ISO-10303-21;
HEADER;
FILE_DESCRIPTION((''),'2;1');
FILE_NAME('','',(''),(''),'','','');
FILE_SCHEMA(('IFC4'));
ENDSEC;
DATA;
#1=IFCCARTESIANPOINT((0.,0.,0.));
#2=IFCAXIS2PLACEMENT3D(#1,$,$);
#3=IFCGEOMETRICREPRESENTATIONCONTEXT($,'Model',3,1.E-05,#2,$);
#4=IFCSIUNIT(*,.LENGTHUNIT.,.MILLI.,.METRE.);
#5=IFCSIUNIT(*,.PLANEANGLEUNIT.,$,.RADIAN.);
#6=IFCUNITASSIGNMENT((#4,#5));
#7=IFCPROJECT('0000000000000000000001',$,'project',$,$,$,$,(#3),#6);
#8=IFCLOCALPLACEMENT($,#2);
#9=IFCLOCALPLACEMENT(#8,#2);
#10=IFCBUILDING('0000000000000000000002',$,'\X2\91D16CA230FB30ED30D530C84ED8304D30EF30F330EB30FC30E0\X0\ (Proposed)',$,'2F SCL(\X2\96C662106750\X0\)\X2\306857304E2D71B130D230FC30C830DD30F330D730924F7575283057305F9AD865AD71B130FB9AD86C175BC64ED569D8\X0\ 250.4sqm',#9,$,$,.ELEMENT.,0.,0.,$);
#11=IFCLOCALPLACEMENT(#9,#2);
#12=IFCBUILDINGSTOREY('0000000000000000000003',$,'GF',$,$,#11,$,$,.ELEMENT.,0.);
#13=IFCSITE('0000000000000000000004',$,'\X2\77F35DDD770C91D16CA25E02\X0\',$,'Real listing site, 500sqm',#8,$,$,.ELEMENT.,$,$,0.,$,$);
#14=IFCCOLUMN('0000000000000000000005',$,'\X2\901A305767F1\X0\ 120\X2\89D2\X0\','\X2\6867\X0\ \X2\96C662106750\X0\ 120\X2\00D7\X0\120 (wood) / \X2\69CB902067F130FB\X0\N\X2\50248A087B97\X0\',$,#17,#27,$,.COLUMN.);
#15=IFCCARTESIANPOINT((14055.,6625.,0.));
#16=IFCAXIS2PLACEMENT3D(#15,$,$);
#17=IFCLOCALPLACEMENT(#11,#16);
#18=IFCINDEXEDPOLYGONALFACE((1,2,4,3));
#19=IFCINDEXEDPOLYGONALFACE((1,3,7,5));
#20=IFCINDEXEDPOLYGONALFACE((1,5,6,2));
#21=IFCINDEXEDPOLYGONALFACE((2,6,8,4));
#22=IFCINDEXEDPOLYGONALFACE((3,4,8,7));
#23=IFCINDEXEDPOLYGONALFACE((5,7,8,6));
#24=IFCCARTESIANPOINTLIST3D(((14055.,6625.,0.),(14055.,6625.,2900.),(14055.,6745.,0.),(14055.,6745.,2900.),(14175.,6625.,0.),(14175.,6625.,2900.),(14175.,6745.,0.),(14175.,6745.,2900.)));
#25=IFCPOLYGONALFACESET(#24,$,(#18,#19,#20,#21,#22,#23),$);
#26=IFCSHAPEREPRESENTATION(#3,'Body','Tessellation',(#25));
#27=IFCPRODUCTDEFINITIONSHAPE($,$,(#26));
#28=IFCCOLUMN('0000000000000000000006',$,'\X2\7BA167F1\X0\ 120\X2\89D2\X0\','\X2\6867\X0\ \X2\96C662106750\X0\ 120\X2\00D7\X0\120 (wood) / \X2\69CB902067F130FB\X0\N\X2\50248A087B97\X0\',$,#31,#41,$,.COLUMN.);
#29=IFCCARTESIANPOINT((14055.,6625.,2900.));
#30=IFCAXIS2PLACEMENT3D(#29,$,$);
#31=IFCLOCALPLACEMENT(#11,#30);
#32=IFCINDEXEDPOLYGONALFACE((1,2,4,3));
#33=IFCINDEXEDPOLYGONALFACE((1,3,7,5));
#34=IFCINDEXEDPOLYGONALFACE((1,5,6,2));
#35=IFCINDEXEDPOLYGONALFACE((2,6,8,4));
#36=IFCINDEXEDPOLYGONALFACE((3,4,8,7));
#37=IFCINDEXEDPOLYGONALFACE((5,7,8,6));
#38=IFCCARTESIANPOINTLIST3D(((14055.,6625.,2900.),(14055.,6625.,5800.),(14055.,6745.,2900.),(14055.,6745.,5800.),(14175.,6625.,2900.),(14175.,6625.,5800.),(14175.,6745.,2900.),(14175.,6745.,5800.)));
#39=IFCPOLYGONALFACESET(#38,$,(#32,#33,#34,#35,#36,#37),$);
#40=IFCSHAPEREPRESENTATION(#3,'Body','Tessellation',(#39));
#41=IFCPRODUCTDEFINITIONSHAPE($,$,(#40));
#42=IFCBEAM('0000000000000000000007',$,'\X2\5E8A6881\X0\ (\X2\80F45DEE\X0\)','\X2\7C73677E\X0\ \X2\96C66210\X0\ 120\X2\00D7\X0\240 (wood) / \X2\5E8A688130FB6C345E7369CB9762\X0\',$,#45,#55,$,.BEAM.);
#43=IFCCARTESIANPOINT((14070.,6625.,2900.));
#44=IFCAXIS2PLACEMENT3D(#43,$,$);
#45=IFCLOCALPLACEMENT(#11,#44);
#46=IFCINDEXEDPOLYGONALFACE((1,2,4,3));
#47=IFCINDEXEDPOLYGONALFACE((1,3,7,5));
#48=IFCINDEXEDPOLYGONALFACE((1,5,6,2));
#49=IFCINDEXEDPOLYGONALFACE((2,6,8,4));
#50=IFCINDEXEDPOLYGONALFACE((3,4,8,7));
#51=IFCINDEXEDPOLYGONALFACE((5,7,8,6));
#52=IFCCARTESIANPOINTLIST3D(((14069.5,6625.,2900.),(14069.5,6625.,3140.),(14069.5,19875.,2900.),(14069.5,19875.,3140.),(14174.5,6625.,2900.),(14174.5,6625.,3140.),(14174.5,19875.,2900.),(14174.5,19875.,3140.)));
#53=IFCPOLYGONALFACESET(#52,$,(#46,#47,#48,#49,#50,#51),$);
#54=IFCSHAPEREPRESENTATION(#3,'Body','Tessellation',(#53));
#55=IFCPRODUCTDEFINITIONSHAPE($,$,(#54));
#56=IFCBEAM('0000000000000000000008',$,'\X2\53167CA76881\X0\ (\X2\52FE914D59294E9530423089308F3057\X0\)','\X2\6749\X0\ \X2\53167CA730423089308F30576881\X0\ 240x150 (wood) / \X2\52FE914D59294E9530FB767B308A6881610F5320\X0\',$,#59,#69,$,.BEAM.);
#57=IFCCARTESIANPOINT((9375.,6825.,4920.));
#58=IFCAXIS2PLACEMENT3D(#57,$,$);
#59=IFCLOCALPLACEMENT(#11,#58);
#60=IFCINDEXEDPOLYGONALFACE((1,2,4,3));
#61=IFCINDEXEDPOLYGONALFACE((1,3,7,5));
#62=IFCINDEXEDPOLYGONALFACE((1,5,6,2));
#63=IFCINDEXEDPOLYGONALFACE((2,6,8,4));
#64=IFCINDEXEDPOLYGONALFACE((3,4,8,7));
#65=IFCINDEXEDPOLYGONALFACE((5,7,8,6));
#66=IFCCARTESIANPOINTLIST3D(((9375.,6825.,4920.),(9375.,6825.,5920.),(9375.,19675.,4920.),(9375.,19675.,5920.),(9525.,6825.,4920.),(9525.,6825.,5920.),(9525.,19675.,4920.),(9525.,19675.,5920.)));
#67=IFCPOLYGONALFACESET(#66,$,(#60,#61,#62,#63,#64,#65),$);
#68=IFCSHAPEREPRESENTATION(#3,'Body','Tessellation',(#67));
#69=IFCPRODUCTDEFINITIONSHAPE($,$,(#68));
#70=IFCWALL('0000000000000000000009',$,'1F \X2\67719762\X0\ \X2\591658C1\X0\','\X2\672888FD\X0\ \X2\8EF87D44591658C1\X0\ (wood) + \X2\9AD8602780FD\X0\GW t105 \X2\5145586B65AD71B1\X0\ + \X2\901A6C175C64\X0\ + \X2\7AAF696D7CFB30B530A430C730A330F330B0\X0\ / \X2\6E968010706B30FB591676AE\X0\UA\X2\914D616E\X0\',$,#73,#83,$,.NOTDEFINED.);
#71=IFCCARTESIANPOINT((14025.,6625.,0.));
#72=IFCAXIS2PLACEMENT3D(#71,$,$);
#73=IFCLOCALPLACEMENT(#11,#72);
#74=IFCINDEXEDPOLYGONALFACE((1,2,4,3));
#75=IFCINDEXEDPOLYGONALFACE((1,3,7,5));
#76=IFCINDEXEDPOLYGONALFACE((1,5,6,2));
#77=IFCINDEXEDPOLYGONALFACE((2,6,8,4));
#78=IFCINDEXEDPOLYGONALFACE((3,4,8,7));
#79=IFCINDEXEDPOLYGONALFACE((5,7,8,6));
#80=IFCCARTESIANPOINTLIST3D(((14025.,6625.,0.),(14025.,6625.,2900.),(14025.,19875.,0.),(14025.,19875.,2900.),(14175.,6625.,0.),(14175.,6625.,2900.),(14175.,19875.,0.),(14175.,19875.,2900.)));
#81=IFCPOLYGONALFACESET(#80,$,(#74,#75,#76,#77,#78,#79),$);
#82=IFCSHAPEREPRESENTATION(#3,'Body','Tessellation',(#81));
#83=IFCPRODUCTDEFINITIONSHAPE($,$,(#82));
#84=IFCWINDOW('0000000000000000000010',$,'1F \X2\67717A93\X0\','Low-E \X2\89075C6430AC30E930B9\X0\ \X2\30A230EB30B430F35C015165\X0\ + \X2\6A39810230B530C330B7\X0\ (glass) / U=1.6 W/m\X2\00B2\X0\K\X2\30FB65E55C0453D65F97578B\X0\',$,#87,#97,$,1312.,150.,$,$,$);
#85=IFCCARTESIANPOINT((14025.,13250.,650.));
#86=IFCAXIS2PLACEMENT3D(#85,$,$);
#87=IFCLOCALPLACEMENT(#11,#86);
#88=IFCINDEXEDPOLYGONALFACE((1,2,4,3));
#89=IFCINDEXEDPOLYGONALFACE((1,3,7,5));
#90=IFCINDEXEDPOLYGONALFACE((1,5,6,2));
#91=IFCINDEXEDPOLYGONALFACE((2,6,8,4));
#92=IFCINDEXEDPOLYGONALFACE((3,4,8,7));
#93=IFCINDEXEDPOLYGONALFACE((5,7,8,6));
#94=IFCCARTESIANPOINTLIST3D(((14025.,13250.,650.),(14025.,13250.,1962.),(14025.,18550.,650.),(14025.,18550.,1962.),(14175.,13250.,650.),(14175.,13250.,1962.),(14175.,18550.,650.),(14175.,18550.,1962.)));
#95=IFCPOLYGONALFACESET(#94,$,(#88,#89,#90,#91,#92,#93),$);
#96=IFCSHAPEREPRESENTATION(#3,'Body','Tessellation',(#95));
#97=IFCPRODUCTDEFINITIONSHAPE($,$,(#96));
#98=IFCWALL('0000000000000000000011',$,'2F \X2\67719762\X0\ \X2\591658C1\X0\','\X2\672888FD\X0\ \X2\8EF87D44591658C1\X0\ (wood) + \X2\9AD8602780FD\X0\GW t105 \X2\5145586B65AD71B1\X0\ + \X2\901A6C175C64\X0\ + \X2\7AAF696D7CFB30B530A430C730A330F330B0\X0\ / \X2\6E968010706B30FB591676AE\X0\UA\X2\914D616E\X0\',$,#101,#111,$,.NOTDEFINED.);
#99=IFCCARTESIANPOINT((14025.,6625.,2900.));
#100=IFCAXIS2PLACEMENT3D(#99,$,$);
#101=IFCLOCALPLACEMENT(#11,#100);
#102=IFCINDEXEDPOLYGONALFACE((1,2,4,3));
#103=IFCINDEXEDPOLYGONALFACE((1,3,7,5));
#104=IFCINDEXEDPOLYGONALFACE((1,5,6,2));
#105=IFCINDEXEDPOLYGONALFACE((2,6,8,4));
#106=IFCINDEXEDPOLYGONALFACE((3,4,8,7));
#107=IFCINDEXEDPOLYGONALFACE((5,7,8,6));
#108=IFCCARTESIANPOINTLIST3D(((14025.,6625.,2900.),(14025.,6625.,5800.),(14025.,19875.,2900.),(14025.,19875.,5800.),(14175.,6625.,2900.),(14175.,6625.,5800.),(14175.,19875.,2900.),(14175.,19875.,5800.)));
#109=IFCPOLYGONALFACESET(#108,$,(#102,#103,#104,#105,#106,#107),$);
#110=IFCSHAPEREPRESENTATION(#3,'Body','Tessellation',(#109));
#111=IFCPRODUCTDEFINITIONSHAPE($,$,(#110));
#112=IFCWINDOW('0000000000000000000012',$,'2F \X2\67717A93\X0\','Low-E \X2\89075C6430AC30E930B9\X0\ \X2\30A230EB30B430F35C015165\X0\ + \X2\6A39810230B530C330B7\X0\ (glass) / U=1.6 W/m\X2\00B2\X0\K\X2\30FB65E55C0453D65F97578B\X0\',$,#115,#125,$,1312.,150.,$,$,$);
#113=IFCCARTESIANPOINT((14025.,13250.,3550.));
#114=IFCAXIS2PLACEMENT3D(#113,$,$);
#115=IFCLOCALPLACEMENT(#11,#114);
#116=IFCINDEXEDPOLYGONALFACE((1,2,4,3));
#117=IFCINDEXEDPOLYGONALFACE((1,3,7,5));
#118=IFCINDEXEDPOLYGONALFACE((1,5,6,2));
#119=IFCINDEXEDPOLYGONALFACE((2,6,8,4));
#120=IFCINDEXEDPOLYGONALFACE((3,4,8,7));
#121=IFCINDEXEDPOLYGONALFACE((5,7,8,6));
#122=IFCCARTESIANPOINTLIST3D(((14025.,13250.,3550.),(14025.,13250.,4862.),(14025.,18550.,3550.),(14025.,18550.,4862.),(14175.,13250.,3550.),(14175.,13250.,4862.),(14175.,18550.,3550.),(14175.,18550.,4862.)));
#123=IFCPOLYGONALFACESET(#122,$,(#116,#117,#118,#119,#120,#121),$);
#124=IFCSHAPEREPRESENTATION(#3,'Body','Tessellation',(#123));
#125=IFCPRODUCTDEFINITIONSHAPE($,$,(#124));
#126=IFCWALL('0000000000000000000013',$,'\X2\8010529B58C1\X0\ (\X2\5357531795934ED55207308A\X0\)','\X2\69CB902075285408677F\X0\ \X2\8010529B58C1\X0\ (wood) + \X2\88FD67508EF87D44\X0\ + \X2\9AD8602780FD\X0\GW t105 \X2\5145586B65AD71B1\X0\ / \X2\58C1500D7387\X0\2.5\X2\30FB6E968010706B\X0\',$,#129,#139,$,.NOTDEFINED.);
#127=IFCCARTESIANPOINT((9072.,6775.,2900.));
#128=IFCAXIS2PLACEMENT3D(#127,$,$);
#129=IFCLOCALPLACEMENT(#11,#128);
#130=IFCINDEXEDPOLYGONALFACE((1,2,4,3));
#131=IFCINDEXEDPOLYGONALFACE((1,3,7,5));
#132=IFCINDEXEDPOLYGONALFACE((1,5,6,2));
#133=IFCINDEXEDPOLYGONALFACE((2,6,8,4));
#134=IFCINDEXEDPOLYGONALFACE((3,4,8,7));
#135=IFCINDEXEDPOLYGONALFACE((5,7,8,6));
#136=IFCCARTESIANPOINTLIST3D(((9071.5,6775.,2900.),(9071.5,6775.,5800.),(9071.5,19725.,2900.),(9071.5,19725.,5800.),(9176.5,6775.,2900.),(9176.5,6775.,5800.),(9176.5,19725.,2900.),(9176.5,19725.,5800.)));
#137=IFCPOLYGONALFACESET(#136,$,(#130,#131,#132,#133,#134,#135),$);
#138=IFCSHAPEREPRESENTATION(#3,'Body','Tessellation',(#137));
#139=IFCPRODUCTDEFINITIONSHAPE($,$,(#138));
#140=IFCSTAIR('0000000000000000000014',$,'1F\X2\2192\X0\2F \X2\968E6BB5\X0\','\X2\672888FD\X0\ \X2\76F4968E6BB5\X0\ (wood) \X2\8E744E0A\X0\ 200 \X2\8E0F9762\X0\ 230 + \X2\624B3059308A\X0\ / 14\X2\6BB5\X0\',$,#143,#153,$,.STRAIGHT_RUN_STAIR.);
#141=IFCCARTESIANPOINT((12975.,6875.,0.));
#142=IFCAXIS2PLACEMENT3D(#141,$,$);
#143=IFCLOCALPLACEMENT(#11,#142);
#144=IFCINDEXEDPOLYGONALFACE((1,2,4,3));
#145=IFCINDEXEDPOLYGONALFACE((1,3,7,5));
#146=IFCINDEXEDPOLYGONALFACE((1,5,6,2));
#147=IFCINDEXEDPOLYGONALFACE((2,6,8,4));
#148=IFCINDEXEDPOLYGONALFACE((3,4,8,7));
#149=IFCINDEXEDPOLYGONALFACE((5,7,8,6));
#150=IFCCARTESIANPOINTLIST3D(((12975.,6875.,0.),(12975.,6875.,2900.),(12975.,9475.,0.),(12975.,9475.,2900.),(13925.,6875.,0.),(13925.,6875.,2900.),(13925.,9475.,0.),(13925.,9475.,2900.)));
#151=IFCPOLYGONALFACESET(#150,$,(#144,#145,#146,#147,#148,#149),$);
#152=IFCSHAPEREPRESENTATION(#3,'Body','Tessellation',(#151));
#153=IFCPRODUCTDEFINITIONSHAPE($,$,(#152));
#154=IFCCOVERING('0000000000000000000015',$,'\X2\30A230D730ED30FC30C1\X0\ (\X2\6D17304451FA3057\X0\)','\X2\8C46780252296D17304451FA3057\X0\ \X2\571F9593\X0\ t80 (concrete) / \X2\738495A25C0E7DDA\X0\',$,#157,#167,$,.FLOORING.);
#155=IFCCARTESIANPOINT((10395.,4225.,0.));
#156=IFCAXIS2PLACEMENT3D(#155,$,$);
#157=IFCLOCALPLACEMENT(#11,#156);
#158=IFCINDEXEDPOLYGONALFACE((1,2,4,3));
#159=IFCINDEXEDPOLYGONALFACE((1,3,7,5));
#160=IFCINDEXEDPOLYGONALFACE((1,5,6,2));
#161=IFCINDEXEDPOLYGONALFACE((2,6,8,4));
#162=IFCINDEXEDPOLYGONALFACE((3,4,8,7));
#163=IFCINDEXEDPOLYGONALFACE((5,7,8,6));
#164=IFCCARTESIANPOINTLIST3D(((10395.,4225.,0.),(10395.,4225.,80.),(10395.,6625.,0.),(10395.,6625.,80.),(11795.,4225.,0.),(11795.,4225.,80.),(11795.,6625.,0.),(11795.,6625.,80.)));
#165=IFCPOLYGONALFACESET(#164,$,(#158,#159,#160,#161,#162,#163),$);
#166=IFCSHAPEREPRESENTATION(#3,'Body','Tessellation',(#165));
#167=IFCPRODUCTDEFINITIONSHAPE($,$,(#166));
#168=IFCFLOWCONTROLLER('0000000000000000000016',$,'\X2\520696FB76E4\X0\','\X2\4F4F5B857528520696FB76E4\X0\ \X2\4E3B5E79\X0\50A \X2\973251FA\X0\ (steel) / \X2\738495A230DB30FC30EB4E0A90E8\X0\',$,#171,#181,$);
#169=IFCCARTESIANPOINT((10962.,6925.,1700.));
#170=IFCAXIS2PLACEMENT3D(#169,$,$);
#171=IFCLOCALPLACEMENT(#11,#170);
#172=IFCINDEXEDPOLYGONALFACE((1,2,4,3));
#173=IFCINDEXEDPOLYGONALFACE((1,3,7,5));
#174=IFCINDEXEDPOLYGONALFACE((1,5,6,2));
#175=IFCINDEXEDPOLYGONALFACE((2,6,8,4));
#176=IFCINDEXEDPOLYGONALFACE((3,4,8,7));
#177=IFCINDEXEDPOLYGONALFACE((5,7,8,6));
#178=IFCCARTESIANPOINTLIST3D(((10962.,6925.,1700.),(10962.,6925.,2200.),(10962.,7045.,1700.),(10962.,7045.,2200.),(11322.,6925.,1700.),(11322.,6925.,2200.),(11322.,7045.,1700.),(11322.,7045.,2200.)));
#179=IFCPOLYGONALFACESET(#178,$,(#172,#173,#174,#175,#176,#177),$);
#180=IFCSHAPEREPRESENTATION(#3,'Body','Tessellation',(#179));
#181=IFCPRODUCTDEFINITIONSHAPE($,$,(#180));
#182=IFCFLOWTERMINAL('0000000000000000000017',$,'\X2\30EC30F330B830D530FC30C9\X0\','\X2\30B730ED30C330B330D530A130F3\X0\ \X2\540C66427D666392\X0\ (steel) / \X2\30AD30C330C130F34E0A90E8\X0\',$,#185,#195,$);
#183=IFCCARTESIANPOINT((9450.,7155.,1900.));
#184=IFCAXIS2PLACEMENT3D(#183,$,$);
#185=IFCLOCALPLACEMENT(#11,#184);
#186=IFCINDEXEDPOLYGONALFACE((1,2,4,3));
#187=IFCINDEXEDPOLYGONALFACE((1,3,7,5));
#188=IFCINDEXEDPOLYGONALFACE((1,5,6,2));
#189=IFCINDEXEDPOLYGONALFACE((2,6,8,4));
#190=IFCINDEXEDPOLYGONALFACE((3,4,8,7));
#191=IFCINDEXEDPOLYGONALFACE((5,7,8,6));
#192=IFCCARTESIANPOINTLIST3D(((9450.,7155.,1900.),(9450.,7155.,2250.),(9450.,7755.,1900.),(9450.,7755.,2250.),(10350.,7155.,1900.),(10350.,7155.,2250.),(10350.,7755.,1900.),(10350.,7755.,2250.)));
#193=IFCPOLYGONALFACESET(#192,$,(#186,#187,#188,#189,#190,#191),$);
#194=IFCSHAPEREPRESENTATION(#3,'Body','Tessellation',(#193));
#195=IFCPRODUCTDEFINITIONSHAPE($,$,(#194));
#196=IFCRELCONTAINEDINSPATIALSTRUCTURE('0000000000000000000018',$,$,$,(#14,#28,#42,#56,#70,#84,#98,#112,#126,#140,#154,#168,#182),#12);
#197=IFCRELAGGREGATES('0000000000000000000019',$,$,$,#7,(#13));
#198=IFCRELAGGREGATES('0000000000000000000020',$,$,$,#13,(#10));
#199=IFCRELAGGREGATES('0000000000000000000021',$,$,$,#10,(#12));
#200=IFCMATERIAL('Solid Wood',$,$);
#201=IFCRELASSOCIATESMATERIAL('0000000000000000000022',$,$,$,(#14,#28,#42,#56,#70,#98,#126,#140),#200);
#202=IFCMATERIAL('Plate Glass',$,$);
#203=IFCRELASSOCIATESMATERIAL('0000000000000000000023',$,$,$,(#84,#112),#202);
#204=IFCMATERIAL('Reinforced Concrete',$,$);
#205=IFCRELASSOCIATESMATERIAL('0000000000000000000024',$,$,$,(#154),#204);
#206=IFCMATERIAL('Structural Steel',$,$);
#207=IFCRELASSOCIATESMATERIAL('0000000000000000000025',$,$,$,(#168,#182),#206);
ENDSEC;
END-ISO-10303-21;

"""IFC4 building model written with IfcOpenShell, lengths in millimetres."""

from ifc_helpers import new_model, si_unit, frame, frame_2d, origin, place, context, project, spatial, rectangle, extrude, material, element, fill, save


model = new_model("IFC4")

# Units and contexts
model_context = context("Model", 3, precision=1e-05, world=origin())
ifc_project = project(units=[si_unit("LENGTHUNIT", "METRE", prefix="MILLI"), si_unit("PLANEANGLEUNIT", "RADIAN")], contexts=[model_context])

# Site, building, storey
site_placement = place(None, origin())
site = spatial("IfcSite", under=ifc_project, at=site_placement, Name="石川県金沢市", ObjectType="Real listing site, 500sqm", CompositionType="ELEMENT", RefElevation=0.0)
building_placement = place(site_placement, origin())
building = spatial("IfcBuilding", under=site, at=building_placement, Name="金沢・ロフト付きワンルーム (Proposed)", ObjectType="2F SCL(集成材)と地中熱ヒートポンプを併用した高断熱・高気密仕様 250.4sqm", CompositionType="ELEMENT", ElevationOfRefHeight=0.0, ElevationOfTerrain=0.0)
storey_placement = place(building_placement, origin())
storey = spatial("IfcBuildingStorey", under=building, at=storey_placement, Name="GF", CompositionType="ELEMENT", Elevation=0.0)

# Columns
ifc_material_1 = material(Name="Solid Wood")
column_1_placement = place(storey_placement, frame((14055.0, 6625.0, 0.0)))
element("IfcColumn", 1, at=column_1_placement, inside=storey, material=ifc_material_1, Name="通し柱 120角", Description="桧 集成材 120×120 (wood) / 構造柱・N値計算", PredefinedType="COLUMN", context=model_context, shape_type="SweptSolid", body=[
    extrude(rectangle(XDim=120.0, YDim=120.0, at=frame_2d((60.0, 60.0))), frame((14055.0, 6625.0, 0.0)), (0.0, 0.0, 1.0), 2900.0),
])
column_2_placement = place(storey_placement, frame((14055.0, 6625.0, 2900.0)))
element("IfcColumn", 2, at=column_2_placement, inside=storey, material=ifc_material_1, Name="管柱 120角", Description="桧 集成材 120×120 (wood) / 構造柱・N値計算", PredefinedType="COLUMN", context=model_context, shape_type="SweptSolid", body=[
    extrude(rectangle(XDim=120.0, YDim=120.0, at=frame_2d((60.0, 60.0))), frame((14055.0, 6625.0, 2900.0)), (0.0, 0.0, 1.0), 2900.0),
])

# Beams
beam_1_placement = place(storey_placement, frame((14070.0, 6625.0, 2900.0)))
element("IfcBeam", 3, at=beam_1_placement, inside=storey, material=ifc_material_1, Name="床梁 (胴差)", Description="米松 集成 120×240 (wood) / 床梁・水平構面", PredefinedType="BEAM", context=model_context, shape_type="SweptSolid", body=[
    extrude(rectangle(XDim=105.0, YDim=13250.0, at=frame_2d((52.0, 6625.0))), frame((14070.0, 6625.0, 2900.0)), (0.0, 0.0, 1.0), 240.0),
])
beam_2_placement = place(storey_placement, frame((9375.0, 6825.0, 4920.0)))
element("IfcBeam", 4, at=beam_2_placement, inside=storey, material=ifc_material_1, Name="化粧梁 (勾配天井あらわし)", Description="杉 化粧あらわし梁 240x150 (wood) / 勾配天井・登り梁意匠", PredefinedType="BEAM", context=model_context, shape_type="SweptSolid", body=[
    extrude(rectangle(XDim=150.0, YDim=12850.0, at=frame_2d((75.0, 6425.0))), frame((9375.0, 6825.0, 4920.0)), (0.0, 0.0, 1.0), 1000.0),
])

# Wall, opening, window
wall_1_placement = place(storey_placement, frame((14025.0, 6625.0, 0.0)))
wall_1 = element("IfcWall", 5, at=wall_1_placement, inside=storey, material=ifc_material_1, Name="1F 東面 外壁", Description="木製 軸組外壁 (wood) + 高性能GW t105 充填断熱 + 通気層 + 窯業系サイディング / 準耐火・外皮UA配慮", PredefinedType="NOTDEFINED", context=model_context, shape_type="SweptSolid", body=[
    extrude(rectangle(XDim=150.0, YDim=13250.0, at=frame_2d((75.0, 6625.0))), frame((14025.0, 6625.0, 0.0)), (0.0, 0.0, 1.0), 2900.0),
])
opening_1_placement = place(storey_placement, frame((14025.0, 13250.0, 650.0)))
opening_1 = element("IfcOpeningElement", 6, at=opening_1_placement, cuts=wall_1, PredefinedType="NOTDEFINED", context=model_context, shape_type="SweptSolid", body=[
    extrude(rectangle(XDim=150.0, YDim=5300.0, at=frame_2d((75.0, 2650.0))), frame((14025.0, 13250.0, 650.0)), (0.0, 0.0, 1.0), 1312.0),
])
ifc_material_2 = material(Name="Plate Glass")
window_1_placement = place(storey_placement, frame((14025.0, 13250.0, 650.0)))
window_1 = element("IfcWindow", 7, at=window_1_placement, inside=storey, material=ifc_material_2, Name="1F 東窓", Description="Low-E 複層ガラス アルゴン封入 + 樹脂サッシ (glass) / U=1.6 W/m²K・日射取得型", OverallHeight=1312.0, OverallWidth=150.0, context=model_context, shape_type="SweptSolid", body=[
    extrude(rectangle(XDim=150.0, YDim=5300.0, at=frame_2d((75.0, 2650.0))), frame((14025.0, 13250.0, 650.0)), (0.0, 0.0, 1.0), 1312.0),
])
fill(opening_1, window_1)

# Wall, opening, window
wall_2_placement = place(storey_placement, frame((14025.0, 6625.0, 2900.0)))
wall_2 = element("IfcWall", 8, at=wall_2_placement, inside=storey, material=ifc_material_1, Name="2F 東面 外壁", Description="木製 軸組外壁 (wood) + 高性能GW t105 充填断熱 + 通気層 + 窯業系サイディング / 準耐火・外皮UA配慮", PredefinedType="NOTDEFINED", context=model_context, shape_type="SweptSolid", body=[
    extrude(rectangle(XDim=150.0, YDim=13250.0, at=frame_2d((75.0, 6625.0))), frame((14025.0, 6625.0, 2900.0)), (0.0, 0.0, 1.0), 2900.0),
])
opening_2_placement = place(storey_placement, frame((14025.0, 13250.0, 3550.0)))
opening_2 = element("IfcOpeningElement", 9, at=opening_2_placement, cuts=wall_2, PredefinedType="NOTDEFINED", context=model_context, shape_type="SweptSolid", body=[
    extrude(rectangle(XDim=150.0, YDim=5300.0, at=frame_2d((75.0, 2650.0))), frame((14025.0, 13250.0, 3550.0)), (0.0, 0.0, 1.0), 1312.0),
])
window_2_placement = place(storey_placement, frame((14025.0, 13250.0, 3550.0)))
window_2 = element("IfcWindow", 10, at=window_2_placement, inside=storey, material=ifc_material_2, Name="2F 東窓", Description="Low-E 複層ガラス アルゴン封入 + 樹脂サッシ (glass) / U=1.6 W/m²K・日射取得型", OverallHeight=1312.0, OverallWidth=150.0, context=model_context, shape_type="SweptSolid", body=[
    extrude(rectangle(XDim=150.0, YDim=5300.0, at=frame_2d((75.0, 2650.0))), frame((14025.0, 13250.0, 3550.0)), (0.0, 0.0, 1.0), 1312.0),
])
fill(opening_2, window_2)

# Wall
wall_3_placement = place(storey_placement, frame((9072.0, 6775.0, 2900.0)))
element("IfcWall", 11, at=wall_3_placement, inside=storey, material=ifc_material_1, Name="耐力壁 (南北間仕切り)", Description="構造用合板 耐力壁 (wood) + 製材軸組 + 高性能GW t105 充填断熱 / 壁倍率2.5・準耐火", PredefinedType="NOTDEFINED", context=model_context, shape_type="SweptSolid", body=[
    extrude(rectangle(XDim=105.0, YDim=12950.0, at=frame_2d((52.0, 6475.0))), frame((9072.0, 6775.0, 2900.0)), (0.0, 0.0, 1.0), 2900.0),
])

# Stair
stair_placement = place(storey_placement, frame((12975.0, 6875.0, 0.0)))
element("IfcStair", 12, at=stair_placement, inside=storey, material=ifc_material_1, Name="1F→2F 階段", Description="木製 直階段 (wood) 蹴上 200 踏面 230 + 手すり / 14段", PredefinedType="STRAIGHT_RUN_STAIR", context=model_context, shape_type="SweptSolid", body=[
    extrude(rectangle(XDim=950.0, YDim=2600.0, at=frame_2d((475.0, 1300.0))), frame((12975.0, 6875.0, 0.0)), (0.0, 0.0, 1.0), 2900.0),
])

# Covering
ifc_material_3 = material(Name="Reinforced Concrete")
covering_placement = place(storey_placement, frame((10395.0, 4225.0, 0.0)))
element("IfcCovering", 13, at=covering_placement, inside=storey, material=ifc_material_3, Name="アプローチ (洗い出し)", Description="豆砂利洗い出し 土間 t80 (concrete) / 玄関導線", PredefinedType="FLOORING", context=model_context, shape_type="SweptSolid", body=[
    extrude(rectangle(XDim=1400.0, YDim=2400.0, at=frame_2d((700.0, 1200.0))), frame((10395.0, 4225.0, 0.0)), (0.0, 0.0, 1.0), 80.0),
])

# Flow controller
ifc_material_4 = material(Name="Structural Steel")
flow_controller_placement = place(storey_placement, frame((10962.0, 6925.0, 1700.0)))
element("IfcFlowController", 14, at=flow_controller_placement, inside=storey, material=ifc_material_4, Name="分電盤", Description="住宅用分電盤 主幹50A 露出 (steel) / 玄関ホール上部", context=model_context, shape_type="SweptSolid", body=[
    extrude(rectangle(XDim=360.0, YDim=120.0, at=frame_2d((180.0, 60.0))), frame((10962.0, 6925.0, 1700.0)), (0.0, 0.0, 1.0), 500.0),
])

# Flow terminal
flow_terminal_1_placement = place(storey_placement, frame((9450.0, 7155.0, 1900.0)))
element("IfcFlowTerminal", 15, at=flow_terminal_1_placement, inside=storey, material=ifc_material_4, Name="レンジフード", Description="シロッコファン 同時給排 (steel) / キッチン上部", context=model_context, shape_type="SweptSolid", body=[
    extrude(rectangle(XDim=900.0, YDim=600.0, at=frame_2d((450.0, 300.0))), frame((9450.0, 7155.0, 1900.0)), (0.0, 0.0, 1.0), 350.0),
])

save(model, "model.ifc")
